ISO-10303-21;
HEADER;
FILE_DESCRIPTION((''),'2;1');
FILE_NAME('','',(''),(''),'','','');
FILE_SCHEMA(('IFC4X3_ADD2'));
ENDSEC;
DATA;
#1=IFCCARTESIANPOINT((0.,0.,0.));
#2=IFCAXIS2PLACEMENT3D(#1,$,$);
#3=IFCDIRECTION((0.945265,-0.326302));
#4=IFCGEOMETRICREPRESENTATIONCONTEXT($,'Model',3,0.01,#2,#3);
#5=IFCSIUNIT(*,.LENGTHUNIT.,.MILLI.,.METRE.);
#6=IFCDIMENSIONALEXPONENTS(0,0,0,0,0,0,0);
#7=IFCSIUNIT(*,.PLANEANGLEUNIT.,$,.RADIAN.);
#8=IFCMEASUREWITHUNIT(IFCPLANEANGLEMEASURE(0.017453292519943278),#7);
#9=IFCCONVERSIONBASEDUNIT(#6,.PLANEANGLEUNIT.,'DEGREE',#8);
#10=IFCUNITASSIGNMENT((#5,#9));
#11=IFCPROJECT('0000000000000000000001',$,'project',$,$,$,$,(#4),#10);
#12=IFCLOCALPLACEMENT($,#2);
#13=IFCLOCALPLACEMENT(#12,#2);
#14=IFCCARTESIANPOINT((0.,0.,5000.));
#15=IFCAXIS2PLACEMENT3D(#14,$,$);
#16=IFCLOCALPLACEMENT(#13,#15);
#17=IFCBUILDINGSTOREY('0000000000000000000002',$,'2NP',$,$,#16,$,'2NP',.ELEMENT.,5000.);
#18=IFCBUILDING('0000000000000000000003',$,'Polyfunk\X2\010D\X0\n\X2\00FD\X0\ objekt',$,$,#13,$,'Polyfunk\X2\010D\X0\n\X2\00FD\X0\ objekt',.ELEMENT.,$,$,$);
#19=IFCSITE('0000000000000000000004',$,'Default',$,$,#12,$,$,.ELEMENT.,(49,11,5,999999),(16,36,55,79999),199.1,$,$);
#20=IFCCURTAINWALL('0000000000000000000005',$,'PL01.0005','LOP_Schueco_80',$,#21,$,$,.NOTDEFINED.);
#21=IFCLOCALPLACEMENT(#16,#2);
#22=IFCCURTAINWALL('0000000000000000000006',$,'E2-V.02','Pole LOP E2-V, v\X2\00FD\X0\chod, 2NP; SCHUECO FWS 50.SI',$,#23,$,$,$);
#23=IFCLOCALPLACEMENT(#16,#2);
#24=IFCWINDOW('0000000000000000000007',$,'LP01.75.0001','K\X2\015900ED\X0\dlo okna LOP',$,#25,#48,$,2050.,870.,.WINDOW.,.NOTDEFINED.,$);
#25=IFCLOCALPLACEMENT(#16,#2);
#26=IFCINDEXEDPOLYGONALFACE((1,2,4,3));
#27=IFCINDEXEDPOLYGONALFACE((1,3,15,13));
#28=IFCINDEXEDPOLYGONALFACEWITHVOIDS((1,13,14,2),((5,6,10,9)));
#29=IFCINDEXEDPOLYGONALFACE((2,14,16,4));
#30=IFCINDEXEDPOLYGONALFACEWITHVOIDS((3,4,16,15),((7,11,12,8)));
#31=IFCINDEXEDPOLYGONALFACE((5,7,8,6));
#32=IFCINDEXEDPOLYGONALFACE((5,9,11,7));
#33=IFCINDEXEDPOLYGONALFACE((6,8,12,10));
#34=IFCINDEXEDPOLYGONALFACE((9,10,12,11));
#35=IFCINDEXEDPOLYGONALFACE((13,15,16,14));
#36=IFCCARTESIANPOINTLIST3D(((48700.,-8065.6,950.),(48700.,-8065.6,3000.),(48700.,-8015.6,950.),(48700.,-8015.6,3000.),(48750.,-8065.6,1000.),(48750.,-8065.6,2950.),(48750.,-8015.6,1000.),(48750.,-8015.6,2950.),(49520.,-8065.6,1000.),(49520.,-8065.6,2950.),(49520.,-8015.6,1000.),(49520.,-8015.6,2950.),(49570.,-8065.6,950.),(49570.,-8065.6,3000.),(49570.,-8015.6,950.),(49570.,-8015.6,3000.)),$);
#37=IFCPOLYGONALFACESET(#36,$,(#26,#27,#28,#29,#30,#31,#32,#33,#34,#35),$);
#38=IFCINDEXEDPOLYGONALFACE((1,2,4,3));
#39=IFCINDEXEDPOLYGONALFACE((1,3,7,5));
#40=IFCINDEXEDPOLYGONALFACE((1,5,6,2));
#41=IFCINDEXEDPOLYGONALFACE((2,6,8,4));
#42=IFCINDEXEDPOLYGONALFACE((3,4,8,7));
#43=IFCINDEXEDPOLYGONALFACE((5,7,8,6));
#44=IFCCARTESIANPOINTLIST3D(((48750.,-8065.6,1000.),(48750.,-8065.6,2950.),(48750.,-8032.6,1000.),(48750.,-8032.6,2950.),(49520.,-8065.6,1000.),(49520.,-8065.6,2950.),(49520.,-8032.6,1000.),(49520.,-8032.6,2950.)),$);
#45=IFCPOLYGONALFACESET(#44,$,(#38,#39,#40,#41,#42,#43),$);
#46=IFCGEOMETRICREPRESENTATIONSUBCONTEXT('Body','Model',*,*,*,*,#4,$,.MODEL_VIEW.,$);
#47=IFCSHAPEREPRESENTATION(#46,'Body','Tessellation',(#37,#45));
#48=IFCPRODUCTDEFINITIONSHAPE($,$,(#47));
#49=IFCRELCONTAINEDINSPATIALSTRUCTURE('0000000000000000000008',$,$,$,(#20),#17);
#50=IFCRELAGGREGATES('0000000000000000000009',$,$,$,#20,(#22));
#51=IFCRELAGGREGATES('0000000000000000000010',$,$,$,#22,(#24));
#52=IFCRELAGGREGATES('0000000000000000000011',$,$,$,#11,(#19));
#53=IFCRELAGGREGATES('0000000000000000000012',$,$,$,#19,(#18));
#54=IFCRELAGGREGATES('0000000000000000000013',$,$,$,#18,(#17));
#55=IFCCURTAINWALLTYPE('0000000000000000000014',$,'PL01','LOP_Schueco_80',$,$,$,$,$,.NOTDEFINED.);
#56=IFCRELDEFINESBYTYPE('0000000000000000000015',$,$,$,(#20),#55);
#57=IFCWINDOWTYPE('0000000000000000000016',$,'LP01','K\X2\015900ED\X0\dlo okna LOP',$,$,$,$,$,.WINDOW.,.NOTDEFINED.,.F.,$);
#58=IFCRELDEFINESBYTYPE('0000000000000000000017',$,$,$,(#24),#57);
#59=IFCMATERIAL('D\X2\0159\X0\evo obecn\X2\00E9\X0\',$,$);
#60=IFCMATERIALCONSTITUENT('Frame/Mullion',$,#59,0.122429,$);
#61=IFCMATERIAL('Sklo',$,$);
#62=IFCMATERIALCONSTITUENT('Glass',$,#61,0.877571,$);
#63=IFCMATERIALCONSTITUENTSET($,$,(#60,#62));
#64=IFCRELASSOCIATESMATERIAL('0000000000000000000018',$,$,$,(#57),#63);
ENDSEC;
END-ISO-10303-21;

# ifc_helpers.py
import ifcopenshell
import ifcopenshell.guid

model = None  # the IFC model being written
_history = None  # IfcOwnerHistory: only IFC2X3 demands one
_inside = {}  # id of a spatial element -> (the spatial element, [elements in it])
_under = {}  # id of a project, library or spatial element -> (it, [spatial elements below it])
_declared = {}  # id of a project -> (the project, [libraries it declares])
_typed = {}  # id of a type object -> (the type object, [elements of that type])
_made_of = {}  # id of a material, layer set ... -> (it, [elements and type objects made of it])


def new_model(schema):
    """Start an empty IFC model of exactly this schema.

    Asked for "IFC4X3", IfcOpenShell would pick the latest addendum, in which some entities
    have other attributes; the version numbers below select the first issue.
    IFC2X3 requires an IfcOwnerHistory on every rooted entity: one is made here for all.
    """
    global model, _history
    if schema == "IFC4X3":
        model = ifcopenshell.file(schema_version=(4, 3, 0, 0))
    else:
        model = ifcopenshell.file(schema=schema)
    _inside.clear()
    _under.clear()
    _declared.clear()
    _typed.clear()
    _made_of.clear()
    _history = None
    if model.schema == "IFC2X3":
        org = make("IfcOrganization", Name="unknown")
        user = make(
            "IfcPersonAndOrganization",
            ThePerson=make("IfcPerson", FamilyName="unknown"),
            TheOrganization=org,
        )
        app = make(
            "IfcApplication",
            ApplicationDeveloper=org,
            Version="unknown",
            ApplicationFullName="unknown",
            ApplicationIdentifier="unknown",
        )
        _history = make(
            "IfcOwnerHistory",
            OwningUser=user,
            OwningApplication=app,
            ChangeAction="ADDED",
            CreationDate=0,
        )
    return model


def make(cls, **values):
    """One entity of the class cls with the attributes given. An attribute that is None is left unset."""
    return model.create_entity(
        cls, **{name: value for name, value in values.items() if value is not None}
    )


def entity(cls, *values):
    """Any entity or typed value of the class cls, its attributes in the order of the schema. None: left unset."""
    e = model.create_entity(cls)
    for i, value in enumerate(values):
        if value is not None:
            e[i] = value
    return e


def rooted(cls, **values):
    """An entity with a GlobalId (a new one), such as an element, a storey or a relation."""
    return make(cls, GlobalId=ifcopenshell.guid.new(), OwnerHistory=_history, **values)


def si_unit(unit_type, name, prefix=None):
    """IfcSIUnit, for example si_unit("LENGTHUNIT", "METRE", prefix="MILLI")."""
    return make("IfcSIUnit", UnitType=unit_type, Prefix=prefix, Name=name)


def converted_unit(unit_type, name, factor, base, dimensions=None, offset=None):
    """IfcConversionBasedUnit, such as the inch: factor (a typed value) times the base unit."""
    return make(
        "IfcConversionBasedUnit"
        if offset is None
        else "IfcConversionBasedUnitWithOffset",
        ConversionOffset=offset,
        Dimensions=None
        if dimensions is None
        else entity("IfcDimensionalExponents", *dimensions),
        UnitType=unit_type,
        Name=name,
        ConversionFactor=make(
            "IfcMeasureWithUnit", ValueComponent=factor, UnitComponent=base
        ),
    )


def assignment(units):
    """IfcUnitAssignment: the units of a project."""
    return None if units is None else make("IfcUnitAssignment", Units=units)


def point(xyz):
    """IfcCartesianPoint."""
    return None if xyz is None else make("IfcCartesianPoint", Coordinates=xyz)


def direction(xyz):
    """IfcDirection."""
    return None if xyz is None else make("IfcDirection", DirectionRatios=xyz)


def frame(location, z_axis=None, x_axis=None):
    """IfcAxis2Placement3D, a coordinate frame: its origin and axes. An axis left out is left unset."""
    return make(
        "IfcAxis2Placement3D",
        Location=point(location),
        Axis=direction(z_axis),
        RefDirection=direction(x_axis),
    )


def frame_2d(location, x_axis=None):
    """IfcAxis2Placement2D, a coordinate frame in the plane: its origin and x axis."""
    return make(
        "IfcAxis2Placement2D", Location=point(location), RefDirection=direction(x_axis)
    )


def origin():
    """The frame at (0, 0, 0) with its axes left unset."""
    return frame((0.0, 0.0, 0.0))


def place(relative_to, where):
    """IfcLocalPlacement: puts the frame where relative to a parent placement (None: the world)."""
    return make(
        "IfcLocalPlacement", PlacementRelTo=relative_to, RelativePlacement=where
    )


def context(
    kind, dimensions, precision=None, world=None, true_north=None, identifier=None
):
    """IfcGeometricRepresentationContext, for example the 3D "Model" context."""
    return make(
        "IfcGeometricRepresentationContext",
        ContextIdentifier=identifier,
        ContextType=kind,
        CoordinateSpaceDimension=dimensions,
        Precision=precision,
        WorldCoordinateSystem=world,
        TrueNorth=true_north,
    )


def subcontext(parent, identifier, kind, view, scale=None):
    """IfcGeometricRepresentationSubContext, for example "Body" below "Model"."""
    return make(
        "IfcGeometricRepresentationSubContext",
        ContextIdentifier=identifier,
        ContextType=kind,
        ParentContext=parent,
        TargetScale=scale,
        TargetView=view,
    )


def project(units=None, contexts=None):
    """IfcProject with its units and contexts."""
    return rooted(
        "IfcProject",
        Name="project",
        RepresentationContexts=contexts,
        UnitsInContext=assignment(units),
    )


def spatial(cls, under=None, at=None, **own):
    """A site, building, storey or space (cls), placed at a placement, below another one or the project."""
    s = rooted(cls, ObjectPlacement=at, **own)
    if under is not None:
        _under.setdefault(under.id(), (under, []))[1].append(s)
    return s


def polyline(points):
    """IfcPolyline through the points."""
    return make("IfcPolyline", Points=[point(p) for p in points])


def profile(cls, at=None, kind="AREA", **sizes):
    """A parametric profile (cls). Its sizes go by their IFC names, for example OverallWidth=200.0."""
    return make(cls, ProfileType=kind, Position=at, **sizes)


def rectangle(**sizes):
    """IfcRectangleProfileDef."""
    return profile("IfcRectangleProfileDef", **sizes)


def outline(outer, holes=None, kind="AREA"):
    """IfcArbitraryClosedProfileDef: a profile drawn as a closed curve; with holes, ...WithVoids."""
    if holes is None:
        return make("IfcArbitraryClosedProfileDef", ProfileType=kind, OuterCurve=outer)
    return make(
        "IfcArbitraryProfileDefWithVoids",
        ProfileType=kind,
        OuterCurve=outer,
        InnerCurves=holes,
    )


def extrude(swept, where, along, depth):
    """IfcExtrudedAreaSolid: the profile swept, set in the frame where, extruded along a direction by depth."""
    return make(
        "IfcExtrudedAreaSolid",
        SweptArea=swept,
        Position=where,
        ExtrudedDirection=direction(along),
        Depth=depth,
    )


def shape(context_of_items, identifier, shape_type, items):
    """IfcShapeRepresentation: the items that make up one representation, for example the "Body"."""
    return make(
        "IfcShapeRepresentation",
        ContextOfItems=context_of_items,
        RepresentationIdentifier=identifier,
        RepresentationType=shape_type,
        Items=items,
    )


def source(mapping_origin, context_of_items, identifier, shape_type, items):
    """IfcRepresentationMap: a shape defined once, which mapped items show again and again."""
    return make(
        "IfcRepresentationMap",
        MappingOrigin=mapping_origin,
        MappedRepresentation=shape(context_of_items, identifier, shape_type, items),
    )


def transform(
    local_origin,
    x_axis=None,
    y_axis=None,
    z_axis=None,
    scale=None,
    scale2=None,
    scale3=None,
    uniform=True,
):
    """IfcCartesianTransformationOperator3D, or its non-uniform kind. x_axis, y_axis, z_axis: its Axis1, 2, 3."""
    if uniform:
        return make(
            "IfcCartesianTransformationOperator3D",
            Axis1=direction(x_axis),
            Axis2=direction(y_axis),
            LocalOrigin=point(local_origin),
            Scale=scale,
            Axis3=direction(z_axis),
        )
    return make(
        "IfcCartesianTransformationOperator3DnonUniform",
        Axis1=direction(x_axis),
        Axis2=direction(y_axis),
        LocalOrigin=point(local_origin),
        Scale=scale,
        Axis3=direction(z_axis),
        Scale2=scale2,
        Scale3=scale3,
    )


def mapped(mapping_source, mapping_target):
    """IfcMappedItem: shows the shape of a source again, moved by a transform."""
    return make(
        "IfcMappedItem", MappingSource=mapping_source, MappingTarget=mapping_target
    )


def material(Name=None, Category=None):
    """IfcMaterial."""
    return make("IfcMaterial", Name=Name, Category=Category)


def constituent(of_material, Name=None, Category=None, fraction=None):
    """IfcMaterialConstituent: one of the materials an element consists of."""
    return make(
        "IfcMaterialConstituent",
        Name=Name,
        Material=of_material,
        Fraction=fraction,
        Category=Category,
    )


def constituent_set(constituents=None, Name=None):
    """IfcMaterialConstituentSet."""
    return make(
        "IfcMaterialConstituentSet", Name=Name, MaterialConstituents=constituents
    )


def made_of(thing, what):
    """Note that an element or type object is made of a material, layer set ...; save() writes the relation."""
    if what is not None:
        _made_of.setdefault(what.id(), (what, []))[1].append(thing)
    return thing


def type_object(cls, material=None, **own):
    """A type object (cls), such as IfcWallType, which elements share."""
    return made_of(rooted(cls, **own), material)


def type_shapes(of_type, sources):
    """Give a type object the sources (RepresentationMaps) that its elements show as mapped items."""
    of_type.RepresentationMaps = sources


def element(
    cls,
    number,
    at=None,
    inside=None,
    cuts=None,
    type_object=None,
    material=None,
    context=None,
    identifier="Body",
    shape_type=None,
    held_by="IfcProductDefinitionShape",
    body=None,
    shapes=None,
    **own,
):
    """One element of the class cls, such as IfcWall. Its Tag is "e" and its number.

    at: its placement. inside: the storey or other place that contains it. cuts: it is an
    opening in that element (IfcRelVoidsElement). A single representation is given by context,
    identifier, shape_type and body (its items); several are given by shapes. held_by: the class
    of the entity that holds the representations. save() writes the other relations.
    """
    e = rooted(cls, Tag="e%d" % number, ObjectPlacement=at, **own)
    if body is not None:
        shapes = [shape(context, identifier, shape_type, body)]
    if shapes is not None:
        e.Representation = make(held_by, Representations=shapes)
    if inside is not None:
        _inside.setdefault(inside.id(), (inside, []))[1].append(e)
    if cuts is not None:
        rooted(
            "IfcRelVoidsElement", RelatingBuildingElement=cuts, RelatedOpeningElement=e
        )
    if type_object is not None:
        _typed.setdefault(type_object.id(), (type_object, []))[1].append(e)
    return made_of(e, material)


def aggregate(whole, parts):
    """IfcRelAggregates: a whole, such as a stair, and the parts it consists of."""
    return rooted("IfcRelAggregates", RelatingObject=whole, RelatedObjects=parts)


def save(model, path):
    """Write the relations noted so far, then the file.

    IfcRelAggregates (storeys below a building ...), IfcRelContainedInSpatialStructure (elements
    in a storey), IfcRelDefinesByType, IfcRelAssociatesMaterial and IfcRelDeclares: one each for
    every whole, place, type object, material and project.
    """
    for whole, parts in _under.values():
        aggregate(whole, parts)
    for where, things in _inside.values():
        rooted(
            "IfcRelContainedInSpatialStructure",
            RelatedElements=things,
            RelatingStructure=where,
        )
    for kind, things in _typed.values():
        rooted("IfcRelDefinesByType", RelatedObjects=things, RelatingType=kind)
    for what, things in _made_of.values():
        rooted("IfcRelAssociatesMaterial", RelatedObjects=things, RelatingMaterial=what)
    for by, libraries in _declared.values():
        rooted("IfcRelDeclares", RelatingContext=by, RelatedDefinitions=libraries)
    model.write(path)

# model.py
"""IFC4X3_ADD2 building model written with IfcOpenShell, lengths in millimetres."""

from ifc_helpers import new_model, entity, si_unit, converted_unit, direction, frame, frame_2d, origin, place, context, subcontext, project, spatial, polyline, rectangle, outline, extrude, source, transform, mapped, material, constituent, constituent_set, type_object, type_shapes, element, aggregate, save


model = new_model("IFC4X3_ADD2")

# Units and contexts
model_context = context("Model", 3, precision=0.01, world=origin(), true_north=direction((0.945265, -0.326302)))
body_context = subcontext(model_context, "Body", "Model", "MODEL_VIEW")
ifc_project = project(units=[si_unit("LENGTHUNIT", "METRE", prefix="MILLI"), converted_unit("PLANEANGLEUNIT", "DEGREE", entity("IfcPlaneAngleMeasure", 0.017453292519943278), si_unit("PLANEANGLEUNIT", "RADIAN"), dimensions=[0, 0, 0, 0, 0, 0, 0])], contexts=[model_context])

# Site, building, storey
site_placement = place(None, origin())
site = spatial("IfcSite", under=ifc_project, at=site_placement, Name="Default", CompositionType="ELEMENT", RefLatitude=(49, 11, 5, 999999), RefLongitude=(16, 36, 55, 79999), RefElevation=199.1)
building_placement = place(site_placement, origin())
building = spatial("IfcBuilding", under=site, at=building_placement, Name="Polyfunkčný objekt", LongName="Polyfunkčný objekt", CompositionType="ELEMENT")
storey_placement = place(building_placement, frame((0.0, 0.0, 5000.0)))
storey = spatial("IfcBuildingStorey", under=building, at=storey_placement, Name="2NP", LongName="2NP", CompositionType="ELEMENT", Elevation=5000.0)

# Curtain walls
curtain_wall_type = type_object("IfcCurtainWallType", Name="PL01", Description="LOP_Schueco_80", PredefinedType="NOTDEFINED")
curtain_wall_1_placement = place(storey_placement, frame((0.0, 0.0, -5000.0)))
curtain_wall_1 = element("IfcCurtainWall", 1, at=curtain_wall_1_placement, inside=storey, type_object=curtain_wall_type, Name="PL01.0005", Description="LOP_Schueco_80", PredefinedType="NOTDEFINED")
curtain_wall_2 = element("IfcCurtainWall", 2, Name="E2-V.02", Description="Pole LOP E2-V, východ, 2NP; SCHUECO FWS 50.SI")
aggregate(curtain_wall_1, [curtain_wall_2])
ifc_material_1 = material(Name="Sklo")

# Window
ifc_material_2 = material(Name="Dřevo obecné")
ifc_constituent_1 = constituent(ifc_material_2, Name="Frame/Mullion", fraction=0.122429)
ifc_constituent_2 = constituent(ifc_material_1, Name="Glass", fraction=0.877571)
ifc_constituent_set = constituent_set(constituents=[ifc_constituent_1, ifc_constituent_2])
window_type = type_object("IfcWindowType", Name="LP01", Description="Křídlo okna LOP", ParameterTakesPrecedence=False, PartitioningType="NOTDEFINED", PredefinedType="WINDOW", material=ifc_constituent_set)
shared_shape_1 = source(origin(), body_context, "Body", "SweptSolid", [
    extrude(outline(polyline([(-1025.0, -435.0), (1025.0, -435.0), (1025.0, 435.0), (-1025.0, 435.0), (-1025.0, -435.0)]), holes=[polyline([(-975.0, -385.0), (-975.0, 385.0), (975.0, 385.0), (975.0, -385.0), (-975.0, -385.0)])]), frame((0.0, 50.0, 1025.0), z_axis=(0.0, -1.0, 0.0), x_axis=(0.0, 0.0, -1.0)), (0.0, 0.0, 1.0), 50.0),
    extrude(rectangle(XDim=770.0, YDim=33.0, at=frame_2d((0.0, 0.0), x_axis=(1.0, 0.0))), frame((0.0, 33.5, 50.0), z_axis=(0.0, 0.0, 1.0), x_axis=(-1.0, 0.0, 0.0)), (0.0, 0.0, 1.0), 1950.0),
])
type_shapes(window_type, [shared_shape_1])
window_placement = place(curtain_wall_1_placement, frame((49135.0, -8015.6, 5950.0), z_axis=(0.0, 0.0, 1.0), x_axis=(-1.0, 0.0, 0.0)))
window = element("IfcWindow", 3, at=window_placement, type_object=window_type, Name="LP01.75.0001", Description="Křídlo okna LOP", OverallHeight=2050.0, OverallWidth=870.0, PartitioningType="NOTDEFINED", PredefinedType="WINDOW", context=body_context, shape_type="MappedRepresentation", body=[
    mapped(shared_shape_1, transform((0.0, 0.0, 0.0), scale=1.0)),
])
aggregate(curtain_wall_2, [window])

save(model, "model.ifc")
